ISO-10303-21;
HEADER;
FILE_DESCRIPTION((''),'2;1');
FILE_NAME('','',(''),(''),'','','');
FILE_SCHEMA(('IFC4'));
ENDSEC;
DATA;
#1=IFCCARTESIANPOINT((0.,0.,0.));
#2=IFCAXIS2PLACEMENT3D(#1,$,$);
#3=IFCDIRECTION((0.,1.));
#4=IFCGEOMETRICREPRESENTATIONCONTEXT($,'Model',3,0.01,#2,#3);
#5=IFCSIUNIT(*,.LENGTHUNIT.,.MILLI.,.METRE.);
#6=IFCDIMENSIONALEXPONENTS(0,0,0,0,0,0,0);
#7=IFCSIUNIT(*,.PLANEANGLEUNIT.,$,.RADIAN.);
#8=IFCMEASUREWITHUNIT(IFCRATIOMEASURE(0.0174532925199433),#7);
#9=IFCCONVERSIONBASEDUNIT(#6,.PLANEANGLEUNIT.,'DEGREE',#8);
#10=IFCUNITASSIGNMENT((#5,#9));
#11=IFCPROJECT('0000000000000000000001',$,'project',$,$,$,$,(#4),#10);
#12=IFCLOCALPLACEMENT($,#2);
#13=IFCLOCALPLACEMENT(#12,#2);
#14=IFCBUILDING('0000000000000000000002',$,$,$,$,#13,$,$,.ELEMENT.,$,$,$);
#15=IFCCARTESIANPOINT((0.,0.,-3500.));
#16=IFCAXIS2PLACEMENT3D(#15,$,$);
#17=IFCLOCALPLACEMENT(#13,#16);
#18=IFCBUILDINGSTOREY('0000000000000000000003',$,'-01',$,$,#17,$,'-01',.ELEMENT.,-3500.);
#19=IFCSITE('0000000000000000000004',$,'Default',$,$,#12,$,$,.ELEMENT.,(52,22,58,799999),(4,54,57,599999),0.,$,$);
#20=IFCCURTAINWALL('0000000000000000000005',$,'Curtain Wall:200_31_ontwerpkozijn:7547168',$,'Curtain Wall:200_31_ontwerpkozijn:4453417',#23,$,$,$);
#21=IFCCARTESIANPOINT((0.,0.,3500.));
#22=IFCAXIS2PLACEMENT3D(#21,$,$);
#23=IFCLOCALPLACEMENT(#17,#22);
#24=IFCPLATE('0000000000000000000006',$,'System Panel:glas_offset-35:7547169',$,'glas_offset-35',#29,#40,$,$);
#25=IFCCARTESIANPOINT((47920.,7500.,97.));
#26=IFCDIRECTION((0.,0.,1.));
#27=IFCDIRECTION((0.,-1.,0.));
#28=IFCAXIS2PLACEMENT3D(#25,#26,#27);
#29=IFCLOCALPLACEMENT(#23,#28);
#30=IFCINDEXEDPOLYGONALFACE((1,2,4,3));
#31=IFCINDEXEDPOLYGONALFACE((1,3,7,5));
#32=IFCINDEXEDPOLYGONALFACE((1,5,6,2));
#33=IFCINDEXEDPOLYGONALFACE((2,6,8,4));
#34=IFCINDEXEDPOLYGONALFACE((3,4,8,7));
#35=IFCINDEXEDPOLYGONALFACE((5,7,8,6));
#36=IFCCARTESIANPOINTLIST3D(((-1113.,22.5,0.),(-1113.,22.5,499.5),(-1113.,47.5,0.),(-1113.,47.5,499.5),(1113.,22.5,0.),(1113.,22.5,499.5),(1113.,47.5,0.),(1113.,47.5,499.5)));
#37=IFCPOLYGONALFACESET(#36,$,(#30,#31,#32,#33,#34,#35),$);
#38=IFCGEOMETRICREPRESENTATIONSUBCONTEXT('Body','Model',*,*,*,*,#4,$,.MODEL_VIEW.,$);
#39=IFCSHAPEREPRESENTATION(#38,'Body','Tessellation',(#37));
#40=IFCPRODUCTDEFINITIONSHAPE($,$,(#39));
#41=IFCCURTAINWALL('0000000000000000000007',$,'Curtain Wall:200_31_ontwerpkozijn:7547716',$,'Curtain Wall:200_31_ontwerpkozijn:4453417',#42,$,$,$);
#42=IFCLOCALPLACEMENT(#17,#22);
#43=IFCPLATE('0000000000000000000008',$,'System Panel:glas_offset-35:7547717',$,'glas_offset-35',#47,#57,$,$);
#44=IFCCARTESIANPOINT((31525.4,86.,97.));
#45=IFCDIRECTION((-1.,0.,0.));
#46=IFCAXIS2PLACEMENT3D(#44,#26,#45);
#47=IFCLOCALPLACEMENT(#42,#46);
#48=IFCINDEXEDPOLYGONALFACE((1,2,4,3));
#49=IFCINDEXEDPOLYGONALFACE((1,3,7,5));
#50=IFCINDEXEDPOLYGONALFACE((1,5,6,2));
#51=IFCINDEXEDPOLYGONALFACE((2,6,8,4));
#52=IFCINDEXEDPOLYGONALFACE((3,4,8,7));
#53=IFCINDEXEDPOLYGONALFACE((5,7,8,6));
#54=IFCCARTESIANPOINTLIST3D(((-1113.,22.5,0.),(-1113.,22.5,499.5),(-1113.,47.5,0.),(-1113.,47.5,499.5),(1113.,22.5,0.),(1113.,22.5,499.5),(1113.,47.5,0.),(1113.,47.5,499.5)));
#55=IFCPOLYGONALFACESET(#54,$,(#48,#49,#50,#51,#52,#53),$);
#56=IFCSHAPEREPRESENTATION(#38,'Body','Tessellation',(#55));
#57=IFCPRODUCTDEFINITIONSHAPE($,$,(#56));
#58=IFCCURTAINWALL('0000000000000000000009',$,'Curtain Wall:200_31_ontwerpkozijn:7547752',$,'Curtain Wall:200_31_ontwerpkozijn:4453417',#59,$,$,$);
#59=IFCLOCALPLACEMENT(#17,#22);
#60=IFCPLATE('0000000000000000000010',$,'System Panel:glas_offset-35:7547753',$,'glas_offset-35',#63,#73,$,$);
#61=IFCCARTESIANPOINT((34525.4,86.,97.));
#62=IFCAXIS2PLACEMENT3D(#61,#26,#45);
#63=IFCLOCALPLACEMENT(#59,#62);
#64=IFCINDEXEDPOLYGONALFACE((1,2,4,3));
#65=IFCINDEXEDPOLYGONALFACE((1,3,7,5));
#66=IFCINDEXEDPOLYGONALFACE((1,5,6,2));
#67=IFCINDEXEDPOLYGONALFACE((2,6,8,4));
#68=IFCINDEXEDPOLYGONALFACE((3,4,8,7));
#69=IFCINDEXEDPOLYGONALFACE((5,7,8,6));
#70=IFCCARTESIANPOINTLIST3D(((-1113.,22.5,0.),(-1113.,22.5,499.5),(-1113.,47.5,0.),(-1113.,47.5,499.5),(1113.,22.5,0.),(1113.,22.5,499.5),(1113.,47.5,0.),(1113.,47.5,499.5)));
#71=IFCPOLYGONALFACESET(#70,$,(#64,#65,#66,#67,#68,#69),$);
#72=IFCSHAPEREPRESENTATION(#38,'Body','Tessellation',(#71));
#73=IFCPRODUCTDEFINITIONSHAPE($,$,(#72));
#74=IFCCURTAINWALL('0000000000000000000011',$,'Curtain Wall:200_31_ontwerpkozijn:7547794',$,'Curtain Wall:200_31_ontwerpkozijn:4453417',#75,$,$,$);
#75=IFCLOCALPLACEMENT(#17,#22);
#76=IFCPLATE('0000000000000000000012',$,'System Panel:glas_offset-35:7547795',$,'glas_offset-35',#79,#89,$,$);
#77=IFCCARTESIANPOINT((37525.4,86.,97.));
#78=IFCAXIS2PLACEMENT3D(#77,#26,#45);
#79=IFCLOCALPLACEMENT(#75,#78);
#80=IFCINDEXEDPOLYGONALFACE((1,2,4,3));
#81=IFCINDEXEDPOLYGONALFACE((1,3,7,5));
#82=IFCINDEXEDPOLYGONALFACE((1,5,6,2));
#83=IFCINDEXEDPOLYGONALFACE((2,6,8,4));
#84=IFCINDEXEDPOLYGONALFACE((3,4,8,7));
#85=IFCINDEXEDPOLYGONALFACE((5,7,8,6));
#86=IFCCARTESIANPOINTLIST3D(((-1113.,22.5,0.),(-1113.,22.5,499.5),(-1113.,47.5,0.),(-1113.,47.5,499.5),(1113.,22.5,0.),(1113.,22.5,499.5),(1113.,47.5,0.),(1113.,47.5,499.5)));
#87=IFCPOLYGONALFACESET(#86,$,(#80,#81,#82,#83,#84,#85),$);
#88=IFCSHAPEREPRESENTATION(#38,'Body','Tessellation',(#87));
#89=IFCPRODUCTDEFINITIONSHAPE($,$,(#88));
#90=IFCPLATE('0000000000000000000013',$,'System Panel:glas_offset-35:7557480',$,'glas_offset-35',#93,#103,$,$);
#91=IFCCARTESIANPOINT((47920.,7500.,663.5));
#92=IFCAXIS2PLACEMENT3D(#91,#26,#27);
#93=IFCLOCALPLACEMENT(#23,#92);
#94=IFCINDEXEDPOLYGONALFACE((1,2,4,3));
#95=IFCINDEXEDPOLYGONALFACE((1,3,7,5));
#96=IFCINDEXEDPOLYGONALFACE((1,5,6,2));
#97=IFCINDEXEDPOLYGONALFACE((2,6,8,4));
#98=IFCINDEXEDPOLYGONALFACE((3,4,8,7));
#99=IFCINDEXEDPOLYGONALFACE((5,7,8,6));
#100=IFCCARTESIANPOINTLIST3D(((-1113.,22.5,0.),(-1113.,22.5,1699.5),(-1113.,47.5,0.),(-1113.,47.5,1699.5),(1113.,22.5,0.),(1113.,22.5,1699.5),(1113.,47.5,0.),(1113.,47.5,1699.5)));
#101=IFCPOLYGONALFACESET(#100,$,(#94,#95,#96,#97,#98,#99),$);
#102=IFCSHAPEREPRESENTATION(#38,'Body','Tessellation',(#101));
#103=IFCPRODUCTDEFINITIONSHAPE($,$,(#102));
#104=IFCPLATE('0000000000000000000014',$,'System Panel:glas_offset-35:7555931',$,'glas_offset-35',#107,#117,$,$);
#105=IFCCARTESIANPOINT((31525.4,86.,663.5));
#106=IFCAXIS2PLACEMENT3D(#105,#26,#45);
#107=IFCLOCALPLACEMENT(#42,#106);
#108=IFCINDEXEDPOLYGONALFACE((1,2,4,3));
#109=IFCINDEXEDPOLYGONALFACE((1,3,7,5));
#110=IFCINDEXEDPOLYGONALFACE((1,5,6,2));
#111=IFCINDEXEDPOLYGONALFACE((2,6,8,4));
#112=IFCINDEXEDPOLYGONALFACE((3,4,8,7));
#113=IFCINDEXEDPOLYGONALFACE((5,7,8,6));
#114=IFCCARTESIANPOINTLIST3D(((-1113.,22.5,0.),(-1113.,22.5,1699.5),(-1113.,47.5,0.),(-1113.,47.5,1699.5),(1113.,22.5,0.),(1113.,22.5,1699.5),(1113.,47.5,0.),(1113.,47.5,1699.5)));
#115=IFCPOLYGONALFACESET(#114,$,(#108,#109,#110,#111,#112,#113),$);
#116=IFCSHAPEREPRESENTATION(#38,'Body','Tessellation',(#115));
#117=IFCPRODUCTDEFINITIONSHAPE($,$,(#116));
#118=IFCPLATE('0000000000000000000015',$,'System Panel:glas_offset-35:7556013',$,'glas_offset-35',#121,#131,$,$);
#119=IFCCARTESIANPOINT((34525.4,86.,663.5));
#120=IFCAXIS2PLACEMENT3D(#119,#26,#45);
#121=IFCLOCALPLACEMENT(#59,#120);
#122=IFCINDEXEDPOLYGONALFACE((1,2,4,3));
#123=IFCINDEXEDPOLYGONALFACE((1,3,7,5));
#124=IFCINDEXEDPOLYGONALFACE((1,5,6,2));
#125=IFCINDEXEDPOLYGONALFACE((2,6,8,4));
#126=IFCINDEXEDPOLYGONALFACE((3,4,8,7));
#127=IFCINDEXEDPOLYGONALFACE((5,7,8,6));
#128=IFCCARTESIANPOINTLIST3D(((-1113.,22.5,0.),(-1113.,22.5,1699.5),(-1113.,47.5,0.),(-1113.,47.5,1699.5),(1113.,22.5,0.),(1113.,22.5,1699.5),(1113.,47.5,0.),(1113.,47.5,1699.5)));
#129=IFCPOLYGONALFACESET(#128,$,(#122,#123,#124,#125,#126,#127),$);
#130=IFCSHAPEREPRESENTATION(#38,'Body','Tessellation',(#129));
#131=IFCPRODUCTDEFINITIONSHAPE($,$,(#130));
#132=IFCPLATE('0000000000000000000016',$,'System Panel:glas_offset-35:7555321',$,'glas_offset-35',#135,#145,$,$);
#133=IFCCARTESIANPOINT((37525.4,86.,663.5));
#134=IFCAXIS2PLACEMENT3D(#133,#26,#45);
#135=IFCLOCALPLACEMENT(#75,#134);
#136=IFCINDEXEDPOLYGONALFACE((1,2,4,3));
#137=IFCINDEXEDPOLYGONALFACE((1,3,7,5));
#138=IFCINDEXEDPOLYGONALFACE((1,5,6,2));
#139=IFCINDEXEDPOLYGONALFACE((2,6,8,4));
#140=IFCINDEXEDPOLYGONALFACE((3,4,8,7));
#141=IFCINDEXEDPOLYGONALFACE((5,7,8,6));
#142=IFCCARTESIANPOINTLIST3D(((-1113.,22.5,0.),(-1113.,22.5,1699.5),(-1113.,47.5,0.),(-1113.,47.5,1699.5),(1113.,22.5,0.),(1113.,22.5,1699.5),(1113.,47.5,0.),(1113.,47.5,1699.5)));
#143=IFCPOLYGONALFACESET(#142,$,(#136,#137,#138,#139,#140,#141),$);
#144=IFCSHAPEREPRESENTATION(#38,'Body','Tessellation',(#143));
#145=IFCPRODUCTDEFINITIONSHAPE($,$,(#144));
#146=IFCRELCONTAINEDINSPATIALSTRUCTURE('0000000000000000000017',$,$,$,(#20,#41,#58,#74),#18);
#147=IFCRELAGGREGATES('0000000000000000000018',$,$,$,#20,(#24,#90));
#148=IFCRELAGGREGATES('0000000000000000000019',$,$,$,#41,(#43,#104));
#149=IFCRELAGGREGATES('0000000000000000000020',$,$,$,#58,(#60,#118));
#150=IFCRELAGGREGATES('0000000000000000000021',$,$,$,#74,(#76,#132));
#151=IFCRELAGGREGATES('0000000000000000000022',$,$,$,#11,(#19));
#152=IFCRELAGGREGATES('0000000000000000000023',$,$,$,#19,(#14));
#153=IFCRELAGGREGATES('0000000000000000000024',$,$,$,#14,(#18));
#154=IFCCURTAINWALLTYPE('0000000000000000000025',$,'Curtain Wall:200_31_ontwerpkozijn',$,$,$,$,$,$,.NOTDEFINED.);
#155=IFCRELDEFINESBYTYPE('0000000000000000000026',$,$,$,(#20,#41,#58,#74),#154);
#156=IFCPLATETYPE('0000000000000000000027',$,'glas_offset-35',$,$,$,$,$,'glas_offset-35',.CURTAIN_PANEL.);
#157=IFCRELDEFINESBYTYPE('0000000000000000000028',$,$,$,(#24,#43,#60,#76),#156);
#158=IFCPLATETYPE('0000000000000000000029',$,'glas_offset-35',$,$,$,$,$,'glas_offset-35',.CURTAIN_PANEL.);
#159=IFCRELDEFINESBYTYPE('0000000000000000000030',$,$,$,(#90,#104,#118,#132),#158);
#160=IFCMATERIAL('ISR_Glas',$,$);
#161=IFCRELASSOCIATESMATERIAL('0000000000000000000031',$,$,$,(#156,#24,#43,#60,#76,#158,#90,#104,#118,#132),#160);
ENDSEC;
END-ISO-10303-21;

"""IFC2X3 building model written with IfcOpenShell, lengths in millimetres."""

from ifc_helpers import new_model, entity, si_unit, converted_unit, direction, frame, origin, origin_2d_with_axis, place, context, subcontext, project, spatial, rectangle, extrude, source, transform, mapped, material, type_object, type_shapes, element, aggregate, save


model = new_model("IFC2X3")

# Units and contexts
model_context = context("Model", 3, precision=0.01, world=origin(), true_north=direction((0.0, 1.0)))
body_context = subcontext(model_context, "Body", "Model", "MODEL_VIEW")
ifc_project = project(units=[si_unit("LENGTHUNIT", "METRE", prefix="MILLI"), converted_unit("PLANEANGLEUNIT", "DEGREE", entity("IfcRatioMeasure", 0.0174532925199433), si_unit("PLANEANGLEUNIT", "RADIAN"), dimensions=[0, 0, 0, 0, 0, 0, 0])], contexts=[model_context])

# Site, building, storey
site_placement = place(None, origin())
site = spatial("IfcSite", under=ifc_project, at=site_placement, Name="Default", CompositionType="ELEMENT", RefLatitude=(52, 22, 58, 799999), RefLongitude=(4, 54, 57, 599999), RefElevation=0.0)
building_placement = place(site_placement, origin())
building = spatial("IfcBuilding", under=site, at=building_placement, CompositionType="ELEMENT")
storey_placement = place(building_placement, frame((0.0, 0.0, -3500.0)))
storey = spatial("IfcBuildingStorey", under=building, at=storey_placement, Name="-01", LongName="-01", CompositionType="ELEMENT", Elevation=-3500.0)

# Curtain walls, plates
curtain_wall_type = type_object("IfcCurtainWallType", Name="Curtain Wall:200_31_ontwerpkozijn", PredefinedType="NOTDEFINED")
curtain_wall_1_placement = place(storey_placement, frame((0.0, 0.0, 3500.0)))
curtain_wall_1 = element("IfcCurtainWall", 1, at=curtain_wall_1_placement, inside=storey, type_object=curtain_wall_type, Name="Curtain Wall:200_31_ontwerpkozijn:7547168", ObjectType="Curtain Wall:200_31_ontwerpkozijn:4453417")
ifc_material_1 = material(Name="ISR_Glas")
plate_type_1 = type_object("IfcPlateType", Name="glas_offset-35", ElementType="glas_offset-35", PredefinedType="CURTAIN_PANEL", material=ifc_material_1)
shared_shape_1 = source(origin(), body_context, "Body", "SweptSolid", [
    extrude(rectangle(XDim=25.0, YDim=2226.0, at=origin_2d_with_axis()), frame((0.0, 35.0, 0.0), z_axis=(0.0, 0.0, 1.0), x_axis=(0.0, 1.0, 0.0)), (0.0, 0.0, 1.0), 499.5),
])
type_shapes(plate_type_1, [shared_shape_1])
plate_1_placement = place(curtain_wall_1_placement, frame((47920.0, 7500.0, 97.0), z_axis=(0.0, 0.0, 1.0), x_axis=(0.0, -1.0, 0.0)))
plate_1 = element("IfcPlate", 2, at=plate_1_placement, type_object=plate_type_1, material=ifc_material_1, Name="System Panel:glas_offset-35:7547169", ObjectType="glas_offset-35", context=body_context, shape_type="MappedRepresentation", body=[
    mapped(shared_shape_1, transform((0.0, 0.0, 0.0), scale=1.0)),
])
curtain_wall_2_placement = place(storey_placement, frame((0.0, 0.0, 3500.0)))
curtain_wall_2 = element("IfcCurtainWall", 3, at=curtain_wall_2_placement, inside=storey, type_object=curtain_wall_type, Name="Curtain Wall:200_31_ontwerpkozijn:7547716", ObjectType="Curtain Wall:200_31_ontwerpkozijn:4453417")
plate_2_placement = place(curtain_wall_2_placement, frame((31525.4, 86.0, 97.0), z_axis=(0.0, 0.0, 1.0), x_axis=(-1.0, 0.0, 0.0)))
plate_2 = element("IfcPlate", 4, at=plate_2_placement, type_object=plate_type_1, material=ifc_material_1, Name="System Panel:glas_offset-35:7547717", ObjectType="glas_offset-35", context=body_context, shape_type="MappedRepresentation", body=[
    mapped(shared_shape_1, transform((0.0, 0.0, 0.0), scale=1.0)),
])
curtain_wall_3_placement = place(storey_placement, frame((0.0, 0.0, 3500.0)))
curtain_wall_3 = element("IfcCurtainWall", 5, at=curtain_wall_3_placement, inside=storey, type_object=curtain_wall_type, Name="Curtain Wall:200_31_ontwerpkozijn:7547752", ObjectType="Curtain Wall:200_31_ontwerpkozijn:4453417")
plate_3_placement = place(curtain_wall_3_placement, frame((34525.4, 86.0, 97.0), z_axis=(0.0, 0.0, 1.0), x_axis=(-1.0, 0.0, 0.0)))
plate_3 = element("IfcPlate", 6, at=plate_3_placement, type_object=plate_type_1, material=ifc_material_1, Name="System Panel:glas_offset-35:7547753", ObjectType="glas_offset-35", context=body_context, shape_type="MappedRepresentation", body=[
    mapped(shared_shape_1, transform((0.0, 0.0, 0.0), scale=1.0)),
])
curtain_wall_4_placement = place(storey_placement, frame((0.0, 0.0, 3500.0)))
curtain_wall_4 = element("IfcCurtainWall", 7, at=curtain_wall_4_placement, inside=storey, type_object=curtain_wall_type, Name="Curtain Wall:200_31_ontwerpkozijn:7547794", ObjectType="Curtain Wall:200_31_ontwerpkozijn:4453417")
plate_4_placement = place(curtain_wall_4_placement, frame((37525.4, 86.0, 97.0), z_axis=(0.0, 0.0, 1.0), x_axis=(-1.0, 0.0, 0.0)))
plate_4 = element("IfcPlate", 8, at=plate_4_placement, type_object=plate_type_1, material=ifc_material_1, Name="System Panel:glas_offset-35:7547795", ObjectType="glas_offset-35", context=body_context, shape_type="MappedRepresentation", body=[
    mapped(shared_shape_1, transform((0.0, 0.0, 0.0), scale=1.0)),
])

# Plates
plate_type_2 = type_object("IfcPlateType", Name="glas_offset-35", ElementType="glas_offset-35", PredefinedType="CURTAIN_PANEL", material=ifc_material_1)
shared_shape_2 = source(origin(), body_context, "Body", "SweptSolid", [
    extrude(rectangle(XDim=25.0, YDim=2226.0, at=origin_2d_with_axis()), frame((0.0, 35.0, 0.0), z_axis=(0.0, 0.0, 1.0), x_axis=(0.0, 1.0, 0.0)), (0.0, 0.0, 1.0), 1699.5),
])
type_shapes(plate_type_2, [shared_shape_2])
plate_5_placement = place(curtain_wall_1_placement, frame((47920.0, 7500.0, 663.5), z_axis=(0.0, 0.0, 1.0), x_axis=(0.0, -1.0, 0.0)))
plate_5 = element("IfcPlate", 9, at=plate_5_placement, type_object=plate_type_2, material=ifc_material_1, Name="System Panel:glas_offset-35:7557480", ObjectType="glas_offset-35", context=body_context, shape_type="MappedRepresentation", body=[
    mapped(shared_shape_2, transform((0.0, 0.0, 0.0), scale=1.0)),
])
aggregate(curtain_wall_1, [plate_1, plate_5])
plate_6_placement = place(curtain_wall_2_placement, frame((31525.4, 86.0, 663.5), z_axis=(0.0, 0.0, 1.0), x_axis=(-1.0, 0.0, 0.0)))
plate_6 = element("IfcPlate", 10, at=plate_6_placement, type_object=plate_type_2, material=ifc_material_1, Name="System Panel:glas_offset-35:7555931", ObjectType="glas_offset-35", context=body_context, shape_type="MappedRepresentation", body=[
    mapped(shared_shape_2, transform((0.0, 0.0, 0.0), scale=1.0)),
])
aggregate(curtain_wall_2, [plate_2, plate_6])
plate_7_placement = place(curtain_wall_3_placement, frame((34525.4, 86.0, 663.5), z_axis=(0.0, 0.0, 1.0), x_axis=(-1.0, 0.0, 0.0)))
plate_7 = element("IfcPlate", 11, at=plate_7_placement, type_object=plate_type_2, material=ifc_material_1, Name="System Panel:glas_offset-35:7556013", ObjectType="glas_offset-35", context=body_context, shape_type="MappedRepresentation", body=[
    mapped(shared_shape_2, transform((0.0, 0.0, 0.0), scale=1.0)),
])
aggregate(curtain_wall_3, [plate_3, plate_7])
plate_8_placement = place(curtain_wall_4_placement, frame((37525.4, 86.0, 663.5), z_axis=(0.0, 0.0, 1.0), x_axis=(-1.0, 0.0, 0.0)))
plate_8 = element("IfcPlate", 12, at=plate_8_placement, type_object=plate_type_2, material=ifc_material_1, Name="System Panel:glas_offset-35:7555321", ObjectType="glas_offset-35", context=body_context, shape_type="MappedRepresentation", body=[
    mapped(shared_shape_2, transform((0.0, 0.0, 0.0), scale=1.0)),
])
aggregate(curtain_wall_4, [plate_4, plate_8])

save(model, "model.ifc")
